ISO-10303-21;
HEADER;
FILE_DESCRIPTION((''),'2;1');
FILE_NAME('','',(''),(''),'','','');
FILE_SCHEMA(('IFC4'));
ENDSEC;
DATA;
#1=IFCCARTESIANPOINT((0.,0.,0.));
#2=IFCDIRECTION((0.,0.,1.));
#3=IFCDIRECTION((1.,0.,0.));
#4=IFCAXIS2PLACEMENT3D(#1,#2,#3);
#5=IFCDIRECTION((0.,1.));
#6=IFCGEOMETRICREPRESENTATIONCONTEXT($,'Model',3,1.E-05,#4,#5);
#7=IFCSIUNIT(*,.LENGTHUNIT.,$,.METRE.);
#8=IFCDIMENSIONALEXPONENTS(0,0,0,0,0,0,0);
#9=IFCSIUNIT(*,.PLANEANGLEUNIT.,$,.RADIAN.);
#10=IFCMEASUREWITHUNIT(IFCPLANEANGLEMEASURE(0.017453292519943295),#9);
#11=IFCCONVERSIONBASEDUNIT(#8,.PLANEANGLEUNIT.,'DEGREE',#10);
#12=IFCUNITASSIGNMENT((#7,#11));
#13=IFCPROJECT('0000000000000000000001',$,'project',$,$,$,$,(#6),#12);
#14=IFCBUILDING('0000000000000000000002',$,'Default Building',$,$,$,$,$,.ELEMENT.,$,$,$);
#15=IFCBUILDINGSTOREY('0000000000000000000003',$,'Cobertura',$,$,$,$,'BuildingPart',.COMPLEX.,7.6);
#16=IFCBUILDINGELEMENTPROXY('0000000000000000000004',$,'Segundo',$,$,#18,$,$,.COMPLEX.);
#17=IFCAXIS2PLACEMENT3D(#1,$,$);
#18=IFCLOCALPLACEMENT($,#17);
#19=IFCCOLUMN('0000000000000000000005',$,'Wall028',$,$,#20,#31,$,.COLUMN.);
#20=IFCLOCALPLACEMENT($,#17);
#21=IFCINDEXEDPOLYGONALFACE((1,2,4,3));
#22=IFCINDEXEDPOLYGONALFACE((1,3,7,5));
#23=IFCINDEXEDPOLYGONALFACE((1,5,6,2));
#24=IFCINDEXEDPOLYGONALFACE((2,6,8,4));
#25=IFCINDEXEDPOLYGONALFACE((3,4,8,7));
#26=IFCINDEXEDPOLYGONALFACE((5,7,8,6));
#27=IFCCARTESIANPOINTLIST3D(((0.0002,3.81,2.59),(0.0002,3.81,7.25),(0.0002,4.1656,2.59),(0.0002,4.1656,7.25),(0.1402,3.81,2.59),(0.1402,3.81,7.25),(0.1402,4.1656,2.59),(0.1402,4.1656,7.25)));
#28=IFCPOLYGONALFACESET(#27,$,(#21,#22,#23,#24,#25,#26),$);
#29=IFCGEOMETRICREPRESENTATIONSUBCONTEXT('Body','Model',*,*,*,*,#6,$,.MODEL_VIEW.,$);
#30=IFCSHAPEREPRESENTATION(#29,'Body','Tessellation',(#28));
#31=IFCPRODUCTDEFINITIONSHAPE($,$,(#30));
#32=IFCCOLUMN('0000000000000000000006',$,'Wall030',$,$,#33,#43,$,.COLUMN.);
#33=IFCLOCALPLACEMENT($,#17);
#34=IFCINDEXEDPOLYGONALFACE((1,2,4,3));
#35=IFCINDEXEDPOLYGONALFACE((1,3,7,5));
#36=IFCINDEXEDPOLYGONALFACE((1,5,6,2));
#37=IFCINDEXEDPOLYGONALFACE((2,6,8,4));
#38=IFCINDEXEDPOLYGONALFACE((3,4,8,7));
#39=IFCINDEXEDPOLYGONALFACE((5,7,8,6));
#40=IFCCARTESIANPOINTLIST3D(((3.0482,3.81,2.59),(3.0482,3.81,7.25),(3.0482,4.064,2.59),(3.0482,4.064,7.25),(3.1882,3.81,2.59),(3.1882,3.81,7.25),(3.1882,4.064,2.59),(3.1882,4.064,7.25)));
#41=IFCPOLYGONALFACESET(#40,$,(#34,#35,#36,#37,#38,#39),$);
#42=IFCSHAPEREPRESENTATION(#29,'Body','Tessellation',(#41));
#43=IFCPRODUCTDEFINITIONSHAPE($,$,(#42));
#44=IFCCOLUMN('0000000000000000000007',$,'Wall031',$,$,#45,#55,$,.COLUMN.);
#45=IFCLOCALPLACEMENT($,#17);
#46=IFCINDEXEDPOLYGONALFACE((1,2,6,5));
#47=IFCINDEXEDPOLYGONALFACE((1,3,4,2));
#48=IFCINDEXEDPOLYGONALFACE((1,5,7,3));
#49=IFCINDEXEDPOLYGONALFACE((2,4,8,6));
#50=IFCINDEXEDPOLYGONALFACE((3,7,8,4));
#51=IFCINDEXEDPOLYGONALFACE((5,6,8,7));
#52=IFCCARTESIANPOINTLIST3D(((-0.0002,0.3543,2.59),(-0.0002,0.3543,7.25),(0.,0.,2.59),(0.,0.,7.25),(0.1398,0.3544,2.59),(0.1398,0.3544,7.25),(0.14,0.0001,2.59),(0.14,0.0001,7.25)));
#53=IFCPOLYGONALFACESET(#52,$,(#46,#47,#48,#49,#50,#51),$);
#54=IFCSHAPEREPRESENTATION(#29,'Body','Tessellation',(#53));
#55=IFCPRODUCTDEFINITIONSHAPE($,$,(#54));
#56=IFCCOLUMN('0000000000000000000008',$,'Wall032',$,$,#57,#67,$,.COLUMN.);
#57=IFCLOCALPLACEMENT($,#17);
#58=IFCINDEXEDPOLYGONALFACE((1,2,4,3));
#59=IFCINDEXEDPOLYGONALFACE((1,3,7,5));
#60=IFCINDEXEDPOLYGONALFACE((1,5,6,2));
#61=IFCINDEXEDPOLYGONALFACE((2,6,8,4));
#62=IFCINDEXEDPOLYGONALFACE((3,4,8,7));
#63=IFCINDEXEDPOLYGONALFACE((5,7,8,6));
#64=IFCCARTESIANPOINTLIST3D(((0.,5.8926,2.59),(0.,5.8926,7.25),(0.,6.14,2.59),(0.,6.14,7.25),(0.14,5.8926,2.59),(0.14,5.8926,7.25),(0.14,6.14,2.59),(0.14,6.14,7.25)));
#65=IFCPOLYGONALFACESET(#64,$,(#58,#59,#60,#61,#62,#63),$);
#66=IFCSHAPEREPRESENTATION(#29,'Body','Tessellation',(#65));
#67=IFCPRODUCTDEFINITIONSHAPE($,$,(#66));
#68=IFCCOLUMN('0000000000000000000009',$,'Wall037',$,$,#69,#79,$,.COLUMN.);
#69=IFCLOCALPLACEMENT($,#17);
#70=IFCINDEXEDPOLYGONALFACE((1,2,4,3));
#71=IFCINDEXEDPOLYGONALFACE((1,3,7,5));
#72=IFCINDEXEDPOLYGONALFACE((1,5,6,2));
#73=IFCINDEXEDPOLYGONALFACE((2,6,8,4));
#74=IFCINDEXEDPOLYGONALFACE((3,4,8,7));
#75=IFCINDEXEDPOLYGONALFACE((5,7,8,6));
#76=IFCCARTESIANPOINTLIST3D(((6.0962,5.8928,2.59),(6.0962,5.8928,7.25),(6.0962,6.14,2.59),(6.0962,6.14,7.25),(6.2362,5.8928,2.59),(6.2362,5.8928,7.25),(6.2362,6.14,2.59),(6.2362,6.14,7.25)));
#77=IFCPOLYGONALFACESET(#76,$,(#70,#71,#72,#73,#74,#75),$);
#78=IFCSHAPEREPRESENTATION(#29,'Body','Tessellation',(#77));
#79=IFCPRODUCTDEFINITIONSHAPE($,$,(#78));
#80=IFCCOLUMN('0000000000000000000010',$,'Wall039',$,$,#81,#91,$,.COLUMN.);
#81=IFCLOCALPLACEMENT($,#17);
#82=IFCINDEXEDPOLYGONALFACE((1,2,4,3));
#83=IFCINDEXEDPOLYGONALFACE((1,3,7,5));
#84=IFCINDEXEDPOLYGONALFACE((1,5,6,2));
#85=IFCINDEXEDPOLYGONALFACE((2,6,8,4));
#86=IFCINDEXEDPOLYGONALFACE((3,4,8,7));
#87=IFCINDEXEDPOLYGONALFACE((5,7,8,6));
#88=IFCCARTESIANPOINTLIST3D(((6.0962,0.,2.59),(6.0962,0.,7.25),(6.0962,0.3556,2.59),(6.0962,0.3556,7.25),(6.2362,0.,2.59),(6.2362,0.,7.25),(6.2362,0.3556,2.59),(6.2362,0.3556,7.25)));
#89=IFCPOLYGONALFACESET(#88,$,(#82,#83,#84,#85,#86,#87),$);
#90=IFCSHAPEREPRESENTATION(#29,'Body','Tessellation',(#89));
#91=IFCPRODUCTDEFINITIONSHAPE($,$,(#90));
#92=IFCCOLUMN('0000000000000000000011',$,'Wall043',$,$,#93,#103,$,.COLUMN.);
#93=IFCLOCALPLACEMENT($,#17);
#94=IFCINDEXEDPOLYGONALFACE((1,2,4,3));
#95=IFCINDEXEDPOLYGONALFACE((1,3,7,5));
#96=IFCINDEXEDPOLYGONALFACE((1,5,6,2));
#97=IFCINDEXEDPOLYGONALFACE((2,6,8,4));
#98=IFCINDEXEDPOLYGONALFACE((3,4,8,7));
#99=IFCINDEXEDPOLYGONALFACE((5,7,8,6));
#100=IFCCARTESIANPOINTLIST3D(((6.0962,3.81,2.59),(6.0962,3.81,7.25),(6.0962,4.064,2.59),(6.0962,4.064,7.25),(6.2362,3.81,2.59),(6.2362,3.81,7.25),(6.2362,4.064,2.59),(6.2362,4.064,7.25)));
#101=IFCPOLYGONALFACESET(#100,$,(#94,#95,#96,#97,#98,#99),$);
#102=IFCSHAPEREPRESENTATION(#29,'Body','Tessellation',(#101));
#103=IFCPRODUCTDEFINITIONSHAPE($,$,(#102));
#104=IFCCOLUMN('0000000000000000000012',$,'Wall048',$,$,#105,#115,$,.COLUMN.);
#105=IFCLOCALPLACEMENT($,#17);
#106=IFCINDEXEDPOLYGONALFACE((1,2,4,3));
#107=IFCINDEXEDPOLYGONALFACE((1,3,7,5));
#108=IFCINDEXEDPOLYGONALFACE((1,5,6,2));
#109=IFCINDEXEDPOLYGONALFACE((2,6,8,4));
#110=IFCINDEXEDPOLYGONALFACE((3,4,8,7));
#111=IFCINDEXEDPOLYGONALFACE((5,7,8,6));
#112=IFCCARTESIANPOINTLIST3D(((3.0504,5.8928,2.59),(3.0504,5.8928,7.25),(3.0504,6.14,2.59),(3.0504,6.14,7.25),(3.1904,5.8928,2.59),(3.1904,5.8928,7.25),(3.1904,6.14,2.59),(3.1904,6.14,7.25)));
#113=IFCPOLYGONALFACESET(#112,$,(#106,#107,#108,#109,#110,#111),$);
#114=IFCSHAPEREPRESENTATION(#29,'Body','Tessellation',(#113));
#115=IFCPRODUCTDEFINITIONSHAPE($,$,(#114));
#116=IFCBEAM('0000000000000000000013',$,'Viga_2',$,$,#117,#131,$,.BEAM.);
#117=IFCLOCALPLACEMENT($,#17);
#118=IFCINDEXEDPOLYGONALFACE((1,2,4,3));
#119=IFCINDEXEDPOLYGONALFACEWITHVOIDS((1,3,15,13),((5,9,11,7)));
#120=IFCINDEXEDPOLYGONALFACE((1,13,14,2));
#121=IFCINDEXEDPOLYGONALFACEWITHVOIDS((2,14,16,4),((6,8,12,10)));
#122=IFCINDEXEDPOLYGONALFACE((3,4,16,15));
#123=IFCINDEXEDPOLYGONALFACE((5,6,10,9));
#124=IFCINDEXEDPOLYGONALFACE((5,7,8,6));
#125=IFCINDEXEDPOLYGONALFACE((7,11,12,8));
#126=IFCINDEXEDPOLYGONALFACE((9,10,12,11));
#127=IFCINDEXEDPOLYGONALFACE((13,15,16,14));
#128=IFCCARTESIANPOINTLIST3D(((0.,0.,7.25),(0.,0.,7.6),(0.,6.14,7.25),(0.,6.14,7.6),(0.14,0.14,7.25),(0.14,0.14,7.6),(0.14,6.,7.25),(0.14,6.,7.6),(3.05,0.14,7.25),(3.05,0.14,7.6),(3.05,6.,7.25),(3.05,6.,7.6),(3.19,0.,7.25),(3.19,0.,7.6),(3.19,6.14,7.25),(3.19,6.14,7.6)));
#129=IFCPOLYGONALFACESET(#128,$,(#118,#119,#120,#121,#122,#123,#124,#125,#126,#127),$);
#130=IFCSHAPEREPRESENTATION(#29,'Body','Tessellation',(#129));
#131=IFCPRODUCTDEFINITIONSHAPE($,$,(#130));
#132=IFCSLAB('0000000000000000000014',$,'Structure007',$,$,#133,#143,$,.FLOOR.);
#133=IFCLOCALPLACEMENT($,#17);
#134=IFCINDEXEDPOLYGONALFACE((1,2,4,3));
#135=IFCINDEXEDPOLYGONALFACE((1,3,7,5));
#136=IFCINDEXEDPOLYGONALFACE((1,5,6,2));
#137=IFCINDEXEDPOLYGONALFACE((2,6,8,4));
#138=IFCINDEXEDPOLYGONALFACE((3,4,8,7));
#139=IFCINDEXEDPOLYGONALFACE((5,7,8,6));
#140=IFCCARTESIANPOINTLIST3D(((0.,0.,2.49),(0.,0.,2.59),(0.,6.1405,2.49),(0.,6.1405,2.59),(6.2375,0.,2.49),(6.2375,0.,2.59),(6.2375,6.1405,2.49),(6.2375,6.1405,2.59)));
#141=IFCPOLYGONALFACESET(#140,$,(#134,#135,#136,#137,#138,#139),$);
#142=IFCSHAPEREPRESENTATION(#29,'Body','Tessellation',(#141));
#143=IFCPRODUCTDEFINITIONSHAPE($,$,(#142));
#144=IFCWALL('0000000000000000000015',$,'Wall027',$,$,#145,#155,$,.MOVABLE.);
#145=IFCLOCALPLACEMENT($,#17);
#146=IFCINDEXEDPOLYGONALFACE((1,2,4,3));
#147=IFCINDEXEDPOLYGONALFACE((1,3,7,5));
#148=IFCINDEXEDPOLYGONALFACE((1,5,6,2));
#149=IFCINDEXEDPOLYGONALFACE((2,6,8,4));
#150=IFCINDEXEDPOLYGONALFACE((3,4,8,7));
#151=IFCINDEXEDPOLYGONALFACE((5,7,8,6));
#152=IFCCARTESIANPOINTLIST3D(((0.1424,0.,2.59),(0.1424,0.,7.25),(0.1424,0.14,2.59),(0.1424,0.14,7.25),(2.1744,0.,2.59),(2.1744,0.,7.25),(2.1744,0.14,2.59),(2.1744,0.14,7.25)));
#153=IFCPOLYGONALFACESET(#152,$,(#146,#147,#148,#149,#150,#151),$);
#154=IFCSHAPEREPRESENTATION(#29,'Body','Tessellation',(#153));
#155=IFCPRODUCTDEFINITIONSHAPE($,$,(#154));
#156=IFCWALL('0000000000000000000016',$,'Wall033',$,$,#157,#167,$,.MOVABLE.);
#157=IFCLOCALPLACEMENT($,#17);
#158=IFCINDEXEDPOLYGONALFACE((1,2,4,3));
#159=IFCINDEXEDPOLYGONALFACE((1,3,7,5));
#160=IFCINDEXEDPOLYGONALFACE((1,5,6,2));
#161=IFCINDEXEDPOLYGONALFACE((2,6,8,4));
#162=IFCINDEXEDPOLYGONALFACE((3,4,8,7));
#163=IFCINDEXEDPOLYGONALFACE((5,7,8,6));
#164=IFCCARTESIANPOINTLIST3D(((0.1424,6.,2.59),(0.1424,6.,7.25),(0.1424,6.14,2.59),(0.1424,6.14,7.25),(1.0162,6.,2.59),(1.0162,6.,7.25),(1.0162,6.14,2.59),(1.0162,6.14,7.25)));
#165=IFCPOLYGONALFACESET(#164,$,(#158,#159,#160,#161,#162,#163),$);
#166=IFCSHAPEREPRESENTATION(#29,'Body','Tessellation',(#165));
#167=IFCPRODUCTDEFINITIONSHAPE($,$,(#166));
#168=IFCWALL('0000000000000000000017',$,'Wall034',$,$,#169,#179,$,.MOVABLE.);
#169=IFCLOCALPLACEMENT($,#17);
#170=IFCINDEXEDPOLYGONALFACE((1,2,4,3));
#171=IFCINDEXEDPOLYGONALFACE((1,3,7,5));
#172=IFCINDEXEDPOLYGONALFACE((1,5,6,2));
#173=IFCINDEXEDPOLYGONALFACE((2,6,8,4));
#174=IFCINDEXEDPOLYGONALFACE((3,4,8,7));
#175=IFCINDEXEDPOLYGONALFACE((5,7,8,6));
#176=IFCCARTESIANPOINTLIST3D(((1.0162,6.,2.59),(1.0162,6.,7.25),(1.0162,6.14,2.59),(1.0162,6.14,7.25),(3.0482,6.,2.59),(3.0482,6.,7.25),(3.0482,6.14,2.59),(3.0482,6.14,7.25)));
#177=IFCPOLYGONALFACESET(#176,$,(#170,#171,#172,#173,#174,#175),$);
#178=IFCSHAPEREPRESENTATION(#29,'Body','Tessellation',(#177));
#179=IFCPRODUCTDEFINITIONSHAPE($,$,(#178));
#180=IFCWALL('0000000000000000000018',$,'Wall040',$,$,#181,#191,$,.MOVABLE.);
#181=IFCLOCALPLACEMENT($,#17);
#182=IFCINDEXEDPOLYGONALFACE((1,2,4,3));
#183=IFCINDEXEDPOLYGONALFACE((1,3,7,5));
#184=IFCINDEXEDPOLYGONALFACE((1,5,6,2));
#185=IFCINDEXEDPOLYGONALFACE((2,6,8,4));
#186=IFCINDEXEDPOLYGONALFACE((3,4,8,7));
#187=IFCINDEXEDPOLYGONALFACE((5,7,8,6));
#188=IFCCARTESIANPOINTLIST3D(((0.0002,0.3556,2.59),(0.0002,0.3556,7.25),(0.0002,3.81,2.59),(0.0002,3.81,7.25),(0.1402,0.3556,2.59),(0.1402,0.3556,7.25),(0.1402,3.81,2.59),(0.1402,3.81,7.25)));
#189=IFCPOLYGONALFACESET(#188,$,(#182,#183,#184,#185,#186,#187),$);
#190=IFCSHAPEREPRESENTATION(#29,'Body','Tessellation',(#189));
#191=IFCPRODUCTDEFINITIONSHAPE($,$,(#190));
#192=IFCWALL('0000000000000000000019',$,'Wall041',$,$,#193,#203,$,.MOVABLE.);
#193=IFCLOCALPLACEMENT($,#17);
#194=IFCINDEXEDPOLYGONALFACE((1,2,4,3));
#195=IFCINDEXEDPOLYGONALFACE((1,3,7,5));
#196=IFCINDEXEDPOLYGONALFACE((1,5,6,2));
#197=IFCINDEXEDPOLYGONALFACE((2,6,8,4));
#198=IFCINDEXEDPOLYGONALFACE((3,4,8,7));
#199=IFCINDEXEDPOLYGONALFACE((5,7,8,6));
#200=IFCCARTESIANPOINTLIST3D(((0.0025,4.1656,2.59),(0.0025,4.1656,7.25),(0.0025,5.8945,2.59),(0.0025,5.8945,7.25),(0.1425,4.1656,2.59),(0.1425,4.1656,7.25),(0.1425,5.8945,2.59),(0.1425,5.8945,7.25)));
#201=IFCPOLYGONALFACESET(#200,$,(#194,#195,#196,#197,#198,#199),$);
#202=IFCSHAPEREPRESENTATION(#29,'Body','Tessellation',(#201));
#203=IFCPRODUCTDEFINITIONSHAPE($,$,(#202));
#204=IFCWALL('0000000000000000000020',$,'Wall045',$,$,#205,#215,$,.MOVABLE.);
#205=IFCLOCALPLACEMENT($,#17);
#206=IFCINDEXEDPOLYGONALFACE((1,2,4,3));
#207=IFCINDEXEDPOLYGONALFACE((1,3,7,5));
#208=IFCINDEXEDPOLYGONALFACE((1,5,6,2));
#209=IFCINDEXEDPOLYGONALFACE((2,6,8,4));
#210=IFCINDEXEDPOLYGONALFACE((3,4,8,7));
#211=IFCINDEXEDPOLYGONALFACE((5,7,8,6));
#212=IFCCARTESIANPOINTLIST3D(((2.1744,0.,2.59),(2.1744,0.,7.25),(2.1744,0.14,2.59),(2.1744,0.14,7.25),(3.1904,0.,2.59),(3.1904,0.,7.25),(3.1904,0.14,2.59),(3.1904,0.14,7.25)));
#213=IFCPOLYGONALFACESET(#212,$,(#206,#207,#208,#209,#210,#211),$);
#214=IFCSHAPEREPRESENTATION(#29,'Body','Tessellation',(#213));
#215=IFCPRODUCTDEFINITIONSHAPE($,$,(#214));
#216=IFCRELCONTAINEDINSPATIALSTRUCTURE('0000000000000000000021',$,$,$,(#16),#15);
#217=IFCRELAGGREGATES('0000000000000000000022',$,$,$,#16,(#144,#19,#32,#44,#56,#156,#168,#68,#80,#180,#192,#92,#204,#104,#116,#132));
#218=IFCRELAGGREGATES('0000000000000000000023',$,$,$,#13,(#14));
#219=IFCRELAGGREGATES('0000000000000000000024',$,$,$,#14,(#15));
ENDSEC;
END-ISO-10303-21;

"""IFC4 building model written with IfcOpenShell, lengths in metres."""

from ifc_helpers import new_model, entity, si_unit, converted_unit, direction, frame, frame_2d, origin_with_axes, origin_2d_with_axis, place, context, subcontext, project, spatial, polyline, rectangle, outline, extrude, element, aggregate, save


model = new_model("IFC4")

# Units and contexts
model_context = context("Model", 3, precision=1e-05, world=origin_with_axes(), true_north=direction((0.0, 1.0)))
body_context = subcontext(model_context, "Body", "Model", "MODEL_VIEW")
ifc_project = project(units=[si_unit("LENGTHUNIT", "METRE"), converted_unit("PLANEANGLEUNIT", "DEGREE", entity("IfcPlaneAngleMeasure", 0.017453292519943295), si_unit("PLANEANGLEUNIT", "RADIAN"), dimensions=[0, 0, 0, 0, 0, 0, 0])], contexts=[model_context])

# Building, storey
building = spatial("IfcBuilding", under=ifc_project, Name="Default Building", CompositionType="ELEMENT")
storey = spatial("IfcBuildingStorey", under=building, Name="Cobertura", LongName="BuildingPart", CompositionType="COMPLEX", Elevation=7.6)

# Building element proxy, columns, beam, slab, walls
proxy_1 = element("IfcBuildingElementProxy", 1, inside=storey, Name="Segundo", PredefinedType="COMPLEX")
placement = place(None, origin_with_axes())
column_1 = element("IfcColumn", 2, at=placement, Name="Wall028", PredefinedType="COLUMN", context=body_context, shape_type="SweptSolid", body=[
    extrude(rectangle(XDim=0.3556, YDim=0.14, at=frame_2d((0.0, 0.0), x_axis=(0.0, -1.0))), frame((0.0702, 3.9878, 2.59), z_axis=(0.0, 0.0, 1.0), x_axis=(1.0, 0.0, 0.0)), (0.0, 0.0, 1.0), 4.66),
])
column_2 = element("IfcColumn", 3, at=placement, Name="Wall030", PredefinedType="COLUMN", context=body_context, shape_type="SweptSolid", body=[
    extrude(rectangle(XDim=0.254, YDim=0.14, at=frame_2d((0.0, 0.0), x_axis=(0.0, -1.0))), frame((3.1182, 3.937, 2.59), z_axis=(0.0, 0.0, 1.0), x_axis=(1.0, 0.0, 0.0)), (0.0, 0.0, 1.0), 4.66),
])
column_3 = element("IfcColumn", 4, at=placement, Name="Wall031", PredefinedType="COLUMN", context=body_context, shape_type="SweptSolid", body=[
    extrude(rectangle(XDim=0.3543, YDim=0.14, at=frame_2d((0.0, 0.0), x_axis=(0.000447, -1.0))), frame((0.0699, 0.1772, 2.59), z_axis=(0.0, 0.0, 1.0), x_axis=(1.0, 0.0, 0.0)), (0.0, 0.0, 1.0), 4.66),
])
column_4 = element("IfcColumn", 5, at=placement, Name="Wall032", PredefinedType="COLUMN", context=body_context, shape_type="SweptSolid", body=[
    extrude(rectangle(XDim=0.2474, YDim=0.14, at=frame_2d((0.0, 0.0), x_axis=(0.0, -1.0))), frame((0.07, 6.0163, 2.59), z_axis=(0.0, 0.0, 1.0), x_axis=(1.0, 0.0, 0.0)), (0.0, 0.0, 1.0), 4.66),
])
column_5 = element("IfcColumn", 6, at=placement, Name="Wall037", PredefinedType="COLUMN", context=body_context, shape_type="SweptSolid", body=[
    extrude(rectangle(XDim=0.2472, YDim=0.14, at=frame_2d((0.0, 0.0), x_axis=(0.0, -1.0))), frame((6.1662, 6.0164, 2.59), z_axis=(0.0, 0.0, 1.0), x_axis=(1.0, 0.0, 0.0)), (0.0, 0.0, 1.0), 4.66),
])
column_6 = element("IfcColumn", 7, at=placement, Name="Wall039", PredefinedType="COLUMN", context=body_context, shape_type="SweptSolid", body=[
    extrude(rectangle(XDim=0.3556, YDim=0.14, at=frame_2d((0.0, 0.0), x_axis=(0.0, -1.0))), frame((6.1662, 0.1778, 2.59), z_axis=(0.0, 0.0, 1.0), x_axis=(1.0, 0.0, 0.0)), (0.0, 0.0, 1.0), 4.66),
])
column_7 = element("IfcColumn", 8, at=placement, Name="Wall043", PredefinedType="COLUMN", context=body_context, shape_type="SweptSolid", body=[
    extrude(rectangle(XDim=0.254, YDim=0.14, at=frame_2d((0.0, 0.0), x_axis=(0.0, -1.0))), frame((6.1662, 3.937, 2.59), z_axis=(0.0, 0.0, 1.0), x_axis=(1.0, 0.0, 0.0)), (0.0, 0.0, 1.0), 4.66),
])
column_8 = element("IfcColumn", 9, at=placement, Name="Wall048", PredefinedType="COLUMN", context=body_context, shape_type="SweptSolid", body=[
    extrude(rectangle(XDim=0.2472, YDim=0.14, at=frame_2d((0.0, 0.0), x_axis=(0.0, 1.0))), frame((3.1204, 6.0164, 2.59), z_axis=(0.0, 0.0, 1.0), x_axis=(1.0, 0.0, 0.0)), (0.0, 0.0, 1.0), 4.66),
])
beam = element("IfcBeam", 10, at=placement, Name="Viga_2", PredefinedType="BEAM", context=body_context, shape_type="SweptSolid", body=[
    extrude(outline(polyline([(1.595, 3.07), (-1.595, 3.07), (-1.595, -3.07), (1.595, -3.07), (1.595, 3.07)]), holes=[polyline([(-1.455, 2.93), (-1.455, -2.93), (1.455, -2.93), (1.455, 2.93), (-1.455, 2.93)])]), frame((1.595, 3.07, 7.25), z_axis=(0.0, 0.0, 1.0), x_axis=(1.0, 0.0, 0.0)), (0.0, 0.0, 1.0), 0.35),
])
slab = element("IfcSlab", 11, at=placement, Name="Structure007", PredefinedType="FLOOR", context=body_context, shape_type="SweptSolid", body=[
    extrude(rectangle(XDim=6.2375, YDim=6.1405, at=origin_2d_with_axis()), frame((3.1187, 3.0703, 2.49), z_axis=(0.0, 0.0, 1.0), x_axis=(1.0, 0.0, 0.0)), (0.0, 0.0, 1.0), 0.1),
])
wall_1 = element("IfcWall", 12, at=placement, Name="Wall027", PredefinedType="MOVABLE", context=body_context, shape_type="SweptSolid", body=[
    extrude(rectangle(XDim=2.032, YDim=0.14, at=origin_2d_with_axis()), frame((1.1584, 0.07, 2.59), z_axis=(0.0, 0.0, 1.0), x_axis=(1.0, 0.0, 0.0)), (0.0, 0.0, 1.0), 4.66),
])
wall_2 = element("IfcWall", 13, at=placement, Name="Wall033", PredefinedType="MOVABLE", context=body_context, shape_type="SweptSolid", body=[
    extrude(rectangle(XDim=0.8738, YDim=0.14, at=frame_2d((0.0, 0.0), x_axis=(-1.0, 0.0))), frame((0.5793, 6.07, 2.59), z_axis=(0.0, 0.0, 1.0), x_axis=(1.0, 0.0, 0.0)), (0.0, 0.0, 1.0), 4.66),
])
wall_3 = element("IfcWall", 14, at=placement, Name="Wall034", PredefinedType="MOVABLE", context=body_context, shape_type="SweptSolid", body=[
    extrude(rectangle(XDim=2.032, YDim=0.14, at=frame_2d((0.0, 0.0), x_axis=(-1.0, 0.0))), frame((2.0322, 6.07, 2.59), z_axis=(0.0, 0.0, 1.0), x_axis=(1.0, 0.0, 0.0)), (0.0, 0.0, 1.0), 4.66),
])
wall_4 = element("IfcWall", 15, at=placement, Name="Wall040", PredefinedType="MOVABLE", context=body_context, shape_type="SweptSolid", body=[
    extrude(rectangle(XDim=3.4544, YDim=0.14, at=frame_2d((0.0, 0.0), x_axis=(0.0, -1.0))), frame((0.0702, 2.0828, 2.59), z_axis=(0.0, 0.0, 1.0), x_axis=(1.0, 0.0, 0.0)), (0.0, 0.0, 1.0), 4.66),
])
wall_5 = element("IfcWall", 16, at=placement, Name="Wall041", PredefinedType="MOVABLE", context=body_context, shape_type="SweptSolid", body=[
    extrude(rectangle(XDim=1.7289, YDim=0.14, at=frame_2d((0.0, 0.0), x_axis=(0.0, -1.0))), frame((0.0725, 5.0301, 2.59), z_axis=(0.0, 0.0, 1.0), x_axis=(1.0, 0.0, 0.0)), (0.0, 0.0, 1.0), 4.66),
])
wall_6 = element("IfcWall", 17, at=placement, Name="Wall045", PredefinedType="MOVABLE", context=body_context, shape_type="SweptSolid", body=[
    extrude(rectangle(XDim=1.016, YDim=0.14, at=frame_2d((0.0, 0.0), x_axis=(1.0, 0.000003))), frame((2.6824, 0.07, 2.59), z_axis=(0.0, 0.0, 1.0), x_axis=(1.0, 0.0, 0.0)), (0.0, 0.0, 1.0), 4.66),
])
aggregate(proxy_1, [wall_1, column_1, column_2, column_3, column_4, wall_2, wall_3, column_5, column_6, wall_4, wall_5, column_7, wall_6, column_8, beam, slab])

save(model, "model.ifc")
